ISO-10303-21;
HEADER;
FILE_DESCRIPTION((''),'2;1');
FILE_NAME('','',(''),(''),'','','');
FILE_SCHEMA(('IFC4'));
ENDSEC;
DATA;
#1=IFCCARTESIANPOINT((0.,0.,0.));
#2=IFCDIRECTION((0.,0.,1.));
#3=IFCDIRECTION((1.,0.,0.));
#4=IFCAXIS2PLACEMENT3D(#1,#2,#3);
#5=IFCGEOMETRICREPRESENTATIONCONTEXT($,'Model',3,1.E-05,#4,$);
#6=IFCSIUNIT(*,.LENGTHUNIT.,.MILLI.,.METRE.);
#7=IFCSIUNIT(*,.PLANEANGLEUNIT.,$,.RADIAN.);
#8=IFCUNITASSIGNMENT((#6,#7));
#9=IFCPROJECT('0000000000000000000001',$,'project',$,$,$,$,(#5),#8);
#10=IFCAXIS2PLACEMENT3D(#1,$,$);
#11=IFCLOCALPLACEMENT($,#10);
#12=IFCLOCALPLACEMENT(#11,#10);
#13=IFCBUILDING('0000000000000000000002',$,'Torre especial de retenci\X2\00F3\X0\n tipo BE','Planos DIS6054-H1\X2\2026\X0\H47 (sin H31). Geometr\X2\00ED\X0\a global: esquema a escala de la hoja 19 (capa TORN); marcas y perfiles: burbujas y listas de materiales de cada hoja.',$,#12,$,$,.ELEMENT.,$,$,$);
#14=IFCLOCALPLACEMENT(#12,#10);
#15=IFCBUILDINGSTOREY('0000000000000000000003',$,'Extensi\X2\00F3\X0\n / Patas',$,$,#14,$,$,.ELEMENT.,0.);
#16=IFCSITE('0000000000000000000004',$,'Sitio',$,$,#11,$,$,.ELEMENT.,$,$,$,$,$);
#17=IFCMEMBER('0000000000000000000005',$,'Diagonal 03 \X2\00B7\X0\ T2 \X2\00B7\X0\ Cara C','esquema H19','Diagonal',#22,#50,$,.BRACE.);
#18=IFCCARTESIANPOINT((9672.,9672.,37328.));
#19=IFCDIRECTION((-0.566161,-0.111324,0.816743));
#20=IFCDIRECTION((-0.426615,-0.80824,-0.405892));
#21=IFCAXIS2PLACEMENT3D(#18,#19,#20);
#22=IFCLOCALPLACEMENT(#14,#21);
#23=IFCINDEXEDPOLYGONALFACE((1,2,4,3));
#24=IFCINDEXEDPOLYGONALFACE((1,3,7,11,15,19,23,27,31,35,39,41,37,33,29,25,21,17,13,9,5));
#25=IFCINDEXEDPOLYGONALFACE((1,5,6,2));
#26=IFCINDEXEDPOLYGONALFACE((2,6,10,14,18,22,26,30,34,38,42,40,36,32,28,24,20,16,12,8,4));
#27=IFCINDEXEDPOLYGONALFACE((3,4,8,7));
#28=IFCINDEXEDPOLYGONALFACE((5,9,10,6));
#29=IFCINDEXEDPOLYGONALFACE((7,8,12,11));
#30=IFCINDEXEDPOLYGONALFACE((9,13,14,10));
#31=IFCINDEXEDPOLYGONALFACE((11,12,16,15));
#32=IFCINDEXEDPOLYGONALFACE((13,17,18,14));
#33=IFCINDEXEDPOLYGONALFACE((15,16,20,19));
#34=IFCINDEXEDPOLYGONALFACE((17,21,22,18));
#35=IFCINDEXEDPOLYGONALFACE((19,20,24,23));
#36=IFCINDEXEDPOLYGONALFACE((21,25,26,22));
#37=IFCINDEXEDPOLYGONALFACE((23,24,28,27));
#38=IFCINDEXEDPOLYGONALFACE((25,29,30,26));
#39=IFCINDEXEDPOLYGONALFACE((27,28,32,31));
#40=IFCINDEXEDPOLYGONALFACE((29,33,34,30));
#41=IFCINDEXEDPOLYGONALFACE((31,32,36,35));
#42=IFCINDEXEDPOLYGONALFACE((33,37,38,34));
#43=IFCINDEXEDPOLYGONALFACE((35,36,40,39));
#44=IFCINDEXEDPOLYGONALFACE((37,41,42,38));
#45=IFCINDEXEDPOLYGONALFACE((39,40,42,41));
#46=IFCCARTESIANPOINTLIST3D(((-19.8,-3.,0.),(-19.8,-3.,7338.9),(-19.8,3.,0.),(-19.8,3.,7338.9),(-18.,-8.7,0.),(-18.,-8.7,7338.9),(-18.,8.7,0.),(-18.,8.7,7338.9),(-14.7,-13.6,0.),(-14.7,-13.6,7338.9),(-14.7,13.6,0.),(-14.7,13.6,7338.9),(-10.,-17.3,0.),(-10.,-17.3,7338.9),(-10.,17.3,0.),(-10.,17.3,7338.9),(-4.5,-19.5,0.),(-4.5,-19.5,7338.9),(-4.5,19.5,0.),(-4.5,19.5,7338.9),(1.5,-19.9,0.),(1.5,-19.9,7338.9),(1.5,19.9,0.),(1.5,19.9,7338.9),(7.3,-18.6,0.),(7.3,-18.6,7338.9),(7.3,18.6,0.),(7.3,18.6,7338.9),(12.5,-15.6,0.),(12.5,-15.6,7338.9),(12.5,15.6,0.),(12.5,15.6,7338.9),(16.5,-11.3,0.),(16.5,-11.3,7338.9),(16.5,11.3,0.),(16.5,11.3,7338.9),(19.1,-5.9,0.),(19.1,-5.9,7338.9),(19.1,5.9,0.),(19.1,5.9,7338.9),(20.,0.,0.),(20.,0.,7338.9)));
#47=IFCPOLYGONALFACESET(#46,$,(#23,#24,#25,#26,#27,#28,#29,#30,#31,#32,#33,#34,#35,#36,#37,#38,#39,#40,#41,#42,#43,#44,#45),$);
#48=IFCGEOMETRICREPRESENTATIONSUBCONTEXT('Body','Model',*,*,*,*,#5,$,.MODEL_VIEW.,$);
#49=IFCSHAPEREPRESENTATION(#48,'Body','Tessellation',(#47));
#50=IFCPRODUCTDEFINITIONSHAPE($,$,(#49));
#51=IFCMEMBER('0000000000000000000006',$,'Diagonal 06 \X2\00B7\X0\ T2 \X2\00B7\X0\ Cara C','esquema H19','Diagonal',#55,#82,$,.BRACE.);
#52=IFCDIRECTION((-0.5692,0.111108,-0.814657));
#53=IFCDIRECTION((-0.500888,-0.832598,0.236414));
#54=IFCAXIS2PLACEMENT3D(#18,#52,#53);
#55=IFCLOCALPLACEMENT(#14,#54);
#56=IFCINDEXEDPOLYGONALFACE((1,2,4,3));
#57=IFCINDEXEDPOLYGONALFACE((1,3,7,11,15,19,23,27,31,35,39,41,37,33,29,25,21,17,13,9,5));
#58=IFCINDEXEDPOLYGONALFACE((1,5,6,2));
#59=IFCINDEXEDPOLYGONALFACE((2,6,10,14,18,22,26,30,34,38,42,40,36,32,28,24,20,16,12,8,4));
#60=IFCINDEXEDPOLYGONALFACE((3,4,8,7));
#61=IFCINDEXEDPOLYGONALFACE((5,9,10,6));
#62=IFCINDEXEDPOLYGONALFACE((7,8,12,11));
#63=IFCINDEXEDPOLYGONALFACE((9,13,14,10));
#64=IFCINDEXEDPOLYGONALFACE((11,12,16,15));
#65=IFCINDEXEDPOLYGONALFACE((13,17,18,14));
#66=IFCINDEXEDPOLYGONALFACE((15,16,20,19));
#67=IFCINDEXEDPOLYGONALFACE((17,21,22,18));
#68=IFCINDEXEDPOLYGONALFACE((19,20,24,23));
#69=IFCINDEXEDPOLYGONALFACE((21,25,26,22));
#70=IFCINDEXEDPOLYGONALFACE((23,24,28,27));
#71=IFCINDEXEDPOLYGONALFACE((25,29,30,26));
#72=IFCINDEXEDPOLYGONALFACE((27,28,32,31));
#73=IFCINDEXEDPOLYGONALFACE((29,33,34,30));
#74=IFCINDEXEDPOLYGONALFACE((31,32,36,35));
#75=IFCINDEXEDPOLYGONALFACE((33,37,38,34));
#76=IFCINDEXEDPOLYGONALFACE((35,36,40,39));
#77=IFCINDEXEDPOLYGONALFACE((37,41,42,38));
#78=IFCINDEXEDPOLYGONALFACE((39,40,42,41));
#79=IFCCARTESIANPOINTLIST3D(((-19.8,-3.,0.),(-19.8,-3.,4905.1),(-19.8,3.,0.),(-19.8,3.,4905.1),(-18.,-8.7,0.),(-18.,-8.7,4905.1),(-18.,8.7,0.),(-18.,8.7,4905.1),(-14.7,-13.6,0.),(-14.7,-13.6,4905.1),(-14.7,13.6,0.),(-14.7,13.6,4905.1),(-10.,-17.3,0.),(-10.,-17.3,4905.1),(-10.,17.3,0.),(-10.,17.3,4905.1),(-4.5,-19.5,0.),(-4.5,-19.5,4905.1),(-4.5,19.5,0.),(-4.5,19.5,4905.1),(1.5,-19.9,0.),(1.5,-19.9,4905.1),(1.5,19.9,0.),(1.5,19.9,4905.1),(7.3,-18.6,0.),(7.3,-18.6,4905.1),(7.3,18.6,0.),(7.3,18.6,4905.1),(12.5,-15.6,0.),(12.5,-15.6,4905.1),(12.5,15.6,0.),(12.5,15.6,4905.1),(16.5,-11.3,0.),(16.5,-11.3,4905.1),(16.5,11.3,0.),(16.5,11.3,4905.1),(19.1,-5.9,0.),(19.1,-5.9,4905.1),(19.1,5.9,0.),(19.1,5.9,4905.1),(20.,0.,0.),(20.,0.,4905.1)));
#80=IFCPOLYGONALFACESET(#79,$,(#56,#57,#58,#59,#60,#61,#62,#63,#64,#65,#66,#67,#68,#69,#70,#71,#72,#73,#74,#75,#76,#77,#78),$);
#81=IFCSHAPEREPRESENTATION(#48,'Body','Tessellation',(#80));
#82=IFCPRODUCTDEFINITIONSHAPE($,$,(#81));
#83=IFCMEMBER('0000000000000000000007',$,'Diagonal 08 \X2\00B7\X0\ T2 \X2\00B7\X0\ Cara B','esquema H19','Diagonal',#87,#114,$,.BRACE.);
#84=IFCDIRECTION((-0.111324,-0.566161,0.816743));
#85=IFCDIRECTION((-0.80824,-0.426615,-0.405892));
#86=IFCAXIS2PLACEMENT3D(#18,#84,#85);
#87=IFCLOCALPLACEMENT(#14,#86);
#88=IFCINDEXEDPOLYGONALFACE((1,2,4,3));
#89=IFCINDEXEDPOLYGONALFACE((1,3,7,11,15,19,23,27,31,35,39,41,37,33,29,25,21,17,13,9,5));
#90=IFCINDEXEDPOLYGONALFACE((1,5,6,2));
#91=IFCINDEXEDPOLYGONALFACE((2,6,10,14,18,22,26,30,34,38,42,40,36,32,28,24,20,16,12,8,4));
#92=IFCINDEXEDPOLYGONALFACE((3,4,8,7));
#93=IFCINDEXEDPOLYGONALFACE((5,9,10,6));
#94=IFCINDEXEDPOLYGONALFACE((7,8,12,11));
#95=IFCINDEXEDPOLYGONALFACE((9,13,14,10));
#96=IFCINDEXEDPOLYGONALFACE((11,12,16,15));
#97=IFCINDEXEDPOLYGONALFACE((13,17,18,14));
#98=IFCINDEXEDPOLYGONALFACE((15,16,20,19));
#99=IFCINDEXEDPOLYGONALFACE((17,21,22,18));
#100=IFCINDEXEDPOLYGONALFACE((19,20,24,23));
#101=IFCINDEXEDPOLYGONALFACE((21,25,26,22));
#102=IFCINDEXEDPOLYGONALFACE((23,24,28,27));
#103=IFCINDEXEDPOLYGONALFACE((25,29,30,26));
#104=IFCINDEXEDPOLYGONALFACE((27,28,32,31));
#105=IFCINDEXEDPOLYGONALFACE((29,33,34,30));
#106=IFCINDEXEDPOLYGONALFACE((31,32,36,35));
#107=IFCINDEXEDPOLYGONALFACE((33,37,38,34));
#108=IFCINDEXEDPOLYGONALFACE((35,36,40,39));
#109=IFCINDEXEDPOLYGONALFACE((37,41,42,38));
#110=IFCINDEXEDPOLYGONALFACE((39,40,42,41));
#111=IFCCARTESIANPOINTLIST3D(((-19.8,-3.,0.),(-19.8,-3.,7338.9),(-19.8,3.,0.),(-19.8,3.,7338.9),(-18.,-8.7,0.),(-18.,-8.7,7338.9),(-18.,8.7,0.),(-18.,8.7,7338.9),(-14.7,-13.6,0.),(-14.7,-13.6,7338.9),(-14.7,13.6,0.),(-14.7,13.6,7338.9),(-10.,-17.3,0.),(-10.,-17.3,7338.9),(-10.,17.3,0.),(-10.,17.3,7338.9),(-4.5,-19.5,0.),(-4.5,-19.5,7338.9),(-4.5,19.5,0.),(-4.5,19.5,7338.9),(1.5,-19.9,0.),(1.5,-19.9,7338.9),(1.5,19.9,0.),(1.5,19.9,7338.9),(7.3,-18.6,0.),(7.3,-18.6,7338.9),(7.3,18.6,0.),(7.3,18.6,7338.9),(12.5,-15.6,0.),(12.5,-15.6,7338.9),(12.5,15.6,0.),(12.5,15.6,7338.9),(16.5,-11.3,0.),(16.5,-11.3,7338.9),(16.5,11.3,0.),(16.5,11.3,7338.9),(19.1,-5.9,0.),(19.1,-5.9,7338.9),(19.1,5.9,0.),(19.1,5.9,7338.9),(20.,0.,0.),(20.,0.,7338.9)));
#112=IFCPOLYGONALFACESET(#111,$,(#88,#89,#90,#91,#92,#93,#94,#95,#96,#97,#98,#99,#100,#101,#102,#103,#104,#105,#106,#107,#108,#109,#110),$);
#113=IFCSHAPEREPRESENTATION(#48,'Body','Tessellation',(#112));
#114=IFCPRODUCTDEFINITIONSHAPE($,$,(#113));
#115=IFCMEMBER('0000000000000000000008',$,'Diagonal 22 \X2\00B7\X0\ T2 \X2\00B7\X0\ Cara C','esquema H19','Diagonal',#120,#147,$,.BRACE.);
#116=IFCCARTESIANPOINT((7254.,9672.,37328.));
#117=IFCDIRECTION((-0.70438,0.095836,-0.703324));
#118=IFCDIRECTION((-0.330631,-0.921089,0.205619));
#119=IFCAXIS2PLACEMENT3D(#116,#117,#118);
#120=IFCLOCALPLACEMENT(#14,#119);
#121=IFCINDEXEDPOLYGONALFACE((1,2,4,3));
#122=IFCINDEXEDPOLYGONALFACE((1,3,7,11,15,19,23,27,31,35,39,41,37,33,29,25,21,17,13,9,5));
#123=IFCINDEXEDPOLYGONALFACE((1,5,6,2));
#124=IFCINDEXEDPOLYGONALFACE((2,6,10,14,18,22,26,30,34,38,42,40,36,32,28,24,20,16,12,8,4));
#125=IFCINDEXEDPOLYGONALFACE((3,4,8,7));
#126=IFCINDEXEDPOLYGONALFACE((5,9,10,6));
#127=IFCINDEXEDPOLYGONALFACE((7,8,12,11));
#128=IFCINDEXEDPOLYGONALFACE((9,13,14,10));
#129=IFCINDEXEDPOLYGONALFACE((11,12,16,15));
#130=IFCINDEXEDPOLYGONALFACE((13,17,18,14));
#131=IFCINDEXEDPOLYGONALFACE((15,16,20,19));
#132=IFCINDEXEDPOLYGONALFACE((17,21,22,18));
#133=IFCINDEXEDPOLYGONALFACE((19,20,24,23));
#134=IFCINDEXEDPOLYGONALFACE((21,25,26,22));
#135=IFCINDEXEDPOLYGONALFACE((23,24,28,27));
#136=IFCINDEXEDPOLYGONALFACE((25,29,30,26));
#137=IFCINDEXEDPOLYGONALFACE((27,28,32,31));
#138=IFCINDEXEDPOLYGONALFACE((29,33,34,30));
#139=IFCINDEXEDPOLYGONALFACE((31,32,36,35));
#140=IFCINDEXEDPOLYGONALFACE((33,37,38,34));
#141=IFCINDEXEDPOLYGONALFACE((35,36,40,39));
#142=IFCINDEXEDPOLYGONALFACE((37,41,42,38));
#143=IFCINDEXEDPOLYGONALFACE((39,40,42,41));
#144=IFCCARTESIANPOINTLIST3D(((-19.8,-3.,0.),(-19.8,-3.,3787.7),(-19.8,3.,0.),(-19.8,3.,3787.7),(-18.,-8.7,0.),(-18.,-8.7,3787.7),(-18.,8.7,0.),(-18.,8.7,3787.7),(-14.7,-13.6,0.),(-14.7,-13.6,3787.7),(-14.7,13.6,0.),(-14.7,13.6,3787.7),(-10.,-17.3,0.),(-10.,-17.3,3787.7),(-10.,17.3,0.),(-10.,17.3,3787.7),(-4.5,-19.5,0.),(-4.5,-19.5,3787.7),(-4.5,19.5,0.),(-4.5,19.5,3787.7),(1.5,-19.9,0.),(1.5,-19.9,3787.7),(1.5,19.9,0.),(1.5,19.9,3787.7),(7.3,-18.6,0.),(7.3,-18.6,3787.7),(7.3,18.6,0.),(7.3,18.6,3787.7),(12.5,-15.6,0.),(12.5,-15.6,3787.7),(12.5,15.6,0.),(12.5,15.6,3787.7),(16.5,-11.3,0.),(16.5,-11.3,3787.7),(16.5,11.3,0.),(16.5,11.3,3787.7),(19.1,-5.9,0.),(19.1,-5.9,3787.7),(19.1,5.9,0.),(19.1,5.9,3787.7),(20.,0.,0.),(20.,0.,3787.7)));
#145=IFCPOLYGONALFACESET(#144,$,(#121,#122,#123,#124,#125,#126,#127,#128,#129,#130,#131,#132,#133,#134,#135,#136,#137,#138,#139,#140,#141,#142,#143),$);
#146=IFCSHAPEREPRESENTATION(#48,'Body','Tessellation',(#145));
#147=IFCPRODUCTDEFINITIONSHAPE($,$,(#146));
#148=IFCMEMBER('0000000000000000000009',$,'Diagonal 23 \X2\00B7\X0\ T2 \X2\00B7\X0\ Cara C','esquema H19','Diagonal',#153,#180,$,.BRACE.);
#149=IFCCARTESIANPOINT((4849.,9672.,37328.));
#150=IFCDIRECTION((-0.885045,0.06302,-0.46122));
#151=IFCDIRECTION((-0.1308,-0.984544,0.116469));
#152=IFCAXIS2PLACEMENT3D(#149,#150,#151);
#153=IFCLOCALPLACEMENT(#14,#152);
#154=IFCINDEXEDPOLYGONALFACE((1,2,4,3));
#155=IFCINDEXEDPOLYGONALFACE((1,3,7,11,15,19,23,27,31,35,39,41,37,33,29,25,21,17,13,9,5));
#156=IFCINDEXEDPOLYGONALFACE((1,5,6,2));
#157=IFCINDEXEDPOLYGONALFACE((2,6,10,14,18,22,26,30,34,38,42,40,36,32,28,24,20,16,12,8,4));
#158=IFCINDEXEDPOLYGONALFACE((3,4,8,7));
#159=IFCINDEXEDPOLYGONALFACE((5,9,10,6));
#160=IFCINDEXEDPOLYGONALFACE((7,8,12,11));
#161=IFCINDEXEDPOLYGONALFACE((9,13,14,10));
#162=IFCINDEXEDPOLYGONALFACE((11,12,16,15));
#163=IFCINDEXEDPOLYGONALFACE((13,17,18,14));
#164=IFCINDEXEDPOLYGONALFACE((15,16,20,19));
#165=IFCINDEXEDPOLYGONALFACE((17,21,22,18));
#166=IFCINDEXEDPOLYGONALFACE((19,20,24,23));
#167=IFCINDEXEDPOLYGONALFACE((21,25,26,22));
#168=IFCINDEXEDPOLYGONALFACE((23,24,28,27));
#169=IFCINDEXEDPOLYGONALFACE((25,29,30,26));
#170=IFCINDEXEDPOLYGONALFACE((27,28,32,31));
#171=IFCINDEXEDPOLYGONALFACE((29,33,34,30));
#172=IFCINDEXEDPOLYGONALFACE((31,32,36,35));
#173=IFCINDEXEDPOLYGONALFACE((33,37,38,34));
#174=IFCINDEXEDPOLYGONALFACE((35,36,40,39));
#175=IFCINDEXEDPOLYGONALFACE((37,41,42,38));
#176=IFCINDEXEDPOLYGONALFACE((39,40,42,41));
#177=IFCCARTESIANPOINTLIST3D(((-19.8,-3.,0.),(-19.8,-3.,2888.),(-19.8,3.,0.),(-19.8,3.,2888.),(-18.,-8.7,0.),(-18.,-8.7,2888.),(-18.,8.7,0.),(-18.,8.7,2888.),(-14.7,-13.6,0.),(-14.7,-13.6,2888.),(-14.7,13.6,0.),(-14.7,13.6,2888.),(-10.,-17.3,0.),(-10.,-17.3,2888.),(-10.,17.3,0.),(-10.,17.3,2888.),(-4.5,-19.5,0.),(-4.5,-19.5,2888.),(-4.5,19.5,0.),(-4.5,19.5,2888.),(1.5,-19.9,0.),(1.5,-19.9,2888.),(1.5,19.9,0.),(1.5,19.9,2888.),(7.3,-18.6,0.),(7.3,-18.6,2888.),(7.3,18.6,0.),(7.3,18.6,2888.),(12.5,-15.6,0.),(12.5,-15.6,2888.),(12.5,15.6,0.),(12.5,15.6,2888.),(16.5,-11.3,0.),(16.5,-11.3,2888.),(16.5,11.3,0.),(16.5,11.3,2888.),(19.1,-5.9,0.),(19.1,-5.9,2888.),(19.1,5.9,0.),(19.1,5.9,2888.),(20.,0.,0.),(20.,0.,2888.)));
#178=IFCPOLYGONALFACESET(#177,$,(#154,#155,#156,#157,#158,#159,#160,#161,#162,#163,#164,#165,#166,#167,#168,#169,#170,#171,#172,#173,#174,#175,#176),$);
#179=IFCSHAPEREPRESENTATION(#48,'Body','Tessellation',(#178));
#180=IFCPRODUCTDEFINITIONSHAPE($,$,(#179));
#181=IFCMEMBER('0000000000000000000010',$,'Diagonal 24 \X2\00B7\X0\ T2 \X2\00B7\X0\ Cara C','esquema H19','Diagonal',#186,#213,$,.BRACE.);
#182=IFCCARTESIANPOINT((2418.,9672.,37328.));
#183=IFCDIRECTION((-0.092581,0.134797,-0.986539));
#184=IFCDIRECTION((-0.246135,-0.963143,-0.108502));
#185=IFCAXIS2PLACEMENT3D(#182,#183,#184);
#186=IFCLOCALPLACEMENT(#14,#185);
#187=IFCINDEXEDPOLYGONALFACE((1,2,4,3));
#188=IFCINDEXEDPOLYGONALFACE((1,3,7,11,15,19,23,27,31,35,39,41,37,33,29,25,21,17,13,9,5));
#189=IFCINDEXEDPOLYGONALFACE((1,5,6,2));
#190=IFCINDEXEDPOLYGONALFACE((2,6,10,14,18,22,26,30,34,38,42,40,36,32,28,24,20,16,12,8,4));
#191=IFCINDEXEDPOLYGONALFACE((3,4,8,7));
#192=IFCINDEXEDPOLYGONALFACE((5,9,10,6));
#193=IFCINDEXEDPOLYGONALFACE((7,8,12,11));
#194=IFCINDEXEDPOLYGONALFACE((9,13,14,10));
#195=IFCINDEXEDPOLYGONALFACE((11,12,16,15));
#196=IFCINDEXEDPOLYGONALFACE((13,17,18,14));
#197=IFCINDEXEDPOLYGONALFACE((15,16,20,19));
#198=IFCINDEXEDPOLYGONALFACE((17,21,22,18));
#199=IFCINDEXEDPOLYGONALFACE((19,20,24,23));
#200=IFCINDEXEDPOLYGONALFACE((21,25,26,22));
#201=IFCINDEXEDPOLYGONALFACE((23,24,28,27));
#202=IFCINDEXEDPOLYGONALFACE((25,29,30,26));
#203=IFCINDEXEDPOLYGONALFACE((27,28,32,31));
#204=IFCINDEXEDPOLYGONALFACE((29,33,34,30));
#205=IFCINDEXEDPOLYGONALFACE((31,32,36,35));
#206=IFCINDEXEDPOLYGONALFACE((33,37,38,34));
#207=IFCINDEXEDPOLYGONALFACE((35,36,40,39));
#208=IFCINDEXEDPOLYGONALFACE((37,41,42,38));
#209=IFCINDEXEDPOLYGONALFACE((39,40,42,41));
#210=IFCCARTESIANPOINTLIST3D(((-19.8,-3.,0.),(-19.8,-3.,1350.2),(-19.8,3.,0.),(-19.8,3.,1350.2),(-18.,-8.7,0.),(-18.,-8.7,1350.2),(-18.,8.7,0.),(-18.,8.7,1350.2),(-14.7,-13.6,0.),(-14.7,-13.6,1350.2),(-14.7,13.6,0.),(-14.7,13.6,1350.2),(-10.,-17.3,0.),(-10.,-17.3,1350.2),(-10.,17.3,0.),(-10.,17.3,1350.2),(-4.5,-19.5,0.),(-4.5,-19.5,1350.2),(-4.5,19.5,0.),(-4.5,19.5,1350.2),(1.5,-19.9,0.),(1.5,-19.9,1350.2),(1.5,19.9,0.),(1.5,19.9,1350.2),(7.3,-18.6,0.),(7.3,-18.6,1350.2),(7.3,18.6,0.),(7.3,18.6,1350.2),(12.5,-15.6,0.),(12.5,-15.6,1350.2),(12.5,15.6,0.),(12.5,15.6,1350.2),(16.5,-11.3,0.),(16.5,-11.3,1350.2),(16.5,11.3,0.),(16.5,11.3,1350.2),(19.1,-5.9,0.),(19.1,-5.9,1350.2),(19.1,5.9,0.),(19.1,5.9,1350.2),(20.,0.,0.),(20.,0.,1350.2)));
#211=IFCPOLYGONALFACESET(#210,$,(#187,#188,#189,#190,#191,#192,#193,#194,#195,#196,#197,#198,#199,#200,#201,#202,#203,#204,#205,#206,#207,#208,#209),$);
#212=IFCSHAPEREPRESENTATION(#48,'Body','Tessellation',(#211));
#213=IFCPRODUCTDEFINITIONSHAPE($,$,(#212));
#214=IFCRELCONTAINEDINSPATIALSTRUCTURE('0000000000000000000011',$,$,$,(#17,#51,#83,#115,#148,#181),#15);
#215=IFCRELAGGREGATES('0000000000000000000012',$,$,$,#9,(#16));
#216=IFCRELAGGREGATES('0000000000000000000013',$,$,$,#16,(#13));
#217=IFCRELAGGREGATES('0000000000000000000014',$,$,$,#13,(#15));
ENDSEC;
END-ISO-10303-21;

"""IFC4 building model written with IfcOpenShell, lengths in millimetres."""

from ifc_helpers import new_model, si_unit, frame, origin, origin_with_axes, place, context, subcontext, project, spatial, circle, extrude, element, save


model = new_model("IFC4")

# Units and contexts
model_context = context("Model", 3, precision=1e-05, world=origin_with_axes())
body_context = subcontext(model_context, "Body", "Model", "MODEL_VIEW")
ifc_project = project(units=[si_unit("LENGTHUNIT", "METRE", prefix="MILLI"), si_unit("PLANEANGLEUNIT", "RADIAN")], contexts=[model_context])

# Site, building, storey
site_placement = place(None, origin())
site = spatial("IfcSite", under=ifc_project, at=site_placement, Name="Sitio", CompositionType="ELEMENT")
building_placement = place(site_placement, origin())
building = spatial("IfcBuilding", under=site, at=building_placement, Name="Torre especial de retención tipo BE", Description="Planos DIS6054-H1…H47 (sin H31). Geometría global: esquema a escala de la hoja 19 (capa TORN); marcas y perfiles: burbujas y listas de materiales de cada hoja.", CompositionType="ELEMENT")
storey_placement = place(building_placement, origin())
storey = spatial("IfcBuildingStorey", under=building, at=storey_placement, Name="Extensión / Patas", CompositionType="ELEMENT", Elevation=0.0)

# Members
member_1_placement = place(storey_placement, frame((9672.0, 9672.0, 37328.0), z_axis=(-0.566161, -0.111324, 0.816743), x_axis=(-0.426615, -0.80824, -0.405892)))
element("IfcMember", 1, at=member_1_placement, inside=storey, Name="Diagonal 03 · T2 · Cara C", Description="esquema H19", ObjectType="Diagonal", PredefinedType="BRACE", context=body_context, shape_type="SweptSolid", body=[
    extrude(circle(Radius=20.0), None, (0.0, 0.0, 1.0), 7338.9),
])
member_2_placement = place(storey_placement, frame((9672.0, 9672.0, 37328.0), z_axis=(-0.5692, 0.111108, -0.814657), x_axis=(-0.500888, -0.832598, 0.236414)))
element("IfcMember", 2, at=member_2_placement, inside=storey, Name="Diagonal 06 · T2 · Cara C", Description="esquema H19", ObjectType="Diagonal", PredefinedType="BRACE", context=body_context, shape_type="SweptSolid", body=[
    extrude(circle(Radius=20.0), None, (0.0, 0.0, 1.0), 4905.1),
])
member_3_placement = place(storey_placement, frame((9672.0, 9672.0, 37328.0), z_axis=(-0.111324, -0.566161, 0.816743), x_axis=(-0.80824, -0.426615, -0.405892)))
element("IfcMember", 3, at=member_3_placement, inside=storey, Name="Diagonal 08 · T2 · Cara B", Description="esquema H19", ObjectType="Diagonal", PredefinedType="BRACE", context=body_context, shape_type="SweptSolid", body=[
    extrude(circle(Radius=20.0), None, (0.0, 0.0, 1.0), 7338.9),
])
member_4_placement = place(storey_placement, frame((7254.0, 9672.0, 37328.0), z_axis=(-0.70438, 0.095836, -0.703324), x_axis=(-0.330631, -0.921089, 0.205619)))
element("IfcMember", 4, at=member_4_placement, inside=storey, Name="Diagonal 22 · T2 · Cara C", Description="esquema H19", ObjectType="Diagonal", PredefinedType="BRACE", context=body_context, shape_type="SweptSolid", body=[
    extrude(circle(Radius=20.0), None, (0.0, 0.0, 1.0), 3787.7),
])
member_5_placement = place(storey_placement, frame((4849.0, 9672.0, 37328.0), z_axis=(-0.885045, 0.06302, -0.46122), x_axis=(-0.1308, -0.984544, 0.116469)))
element("IfcMember", 5, at=member_5_placement, inside=storey, Name="Diagonal 23 · T2 · Cara C", Description="esquema H19", ObjectType="Diagonal", PredefinedType="BRACE", context=body_context, shape_type="SweptSolid", body=[
    extrude(circle(Radius=20.0), None, (0.0, 0.0, 1.0), 2888.0),
])
member_6_placement = place(storey_placement, frame((2418.0, 9672.0, 37328.0), z_axis=(-0.092581, 0.134797, -0.986539), x_axis=(-0.246135, -0.963143, -0.108502)))
element("IfcMember", 6, at=member_6_placement, inside=storey, Name="Diagonal 24 · T2 · Cara C", Description="esquema H19", ObjectType="Diagonal", PredefinedType="BRACE", context=body_context, shape_type="SweptSolid", body=[
    extrude(circle(Radius=20.0), None, (0.0, 0.0, 1.0), 1350.2),
])

save(model, "model.ifc")
